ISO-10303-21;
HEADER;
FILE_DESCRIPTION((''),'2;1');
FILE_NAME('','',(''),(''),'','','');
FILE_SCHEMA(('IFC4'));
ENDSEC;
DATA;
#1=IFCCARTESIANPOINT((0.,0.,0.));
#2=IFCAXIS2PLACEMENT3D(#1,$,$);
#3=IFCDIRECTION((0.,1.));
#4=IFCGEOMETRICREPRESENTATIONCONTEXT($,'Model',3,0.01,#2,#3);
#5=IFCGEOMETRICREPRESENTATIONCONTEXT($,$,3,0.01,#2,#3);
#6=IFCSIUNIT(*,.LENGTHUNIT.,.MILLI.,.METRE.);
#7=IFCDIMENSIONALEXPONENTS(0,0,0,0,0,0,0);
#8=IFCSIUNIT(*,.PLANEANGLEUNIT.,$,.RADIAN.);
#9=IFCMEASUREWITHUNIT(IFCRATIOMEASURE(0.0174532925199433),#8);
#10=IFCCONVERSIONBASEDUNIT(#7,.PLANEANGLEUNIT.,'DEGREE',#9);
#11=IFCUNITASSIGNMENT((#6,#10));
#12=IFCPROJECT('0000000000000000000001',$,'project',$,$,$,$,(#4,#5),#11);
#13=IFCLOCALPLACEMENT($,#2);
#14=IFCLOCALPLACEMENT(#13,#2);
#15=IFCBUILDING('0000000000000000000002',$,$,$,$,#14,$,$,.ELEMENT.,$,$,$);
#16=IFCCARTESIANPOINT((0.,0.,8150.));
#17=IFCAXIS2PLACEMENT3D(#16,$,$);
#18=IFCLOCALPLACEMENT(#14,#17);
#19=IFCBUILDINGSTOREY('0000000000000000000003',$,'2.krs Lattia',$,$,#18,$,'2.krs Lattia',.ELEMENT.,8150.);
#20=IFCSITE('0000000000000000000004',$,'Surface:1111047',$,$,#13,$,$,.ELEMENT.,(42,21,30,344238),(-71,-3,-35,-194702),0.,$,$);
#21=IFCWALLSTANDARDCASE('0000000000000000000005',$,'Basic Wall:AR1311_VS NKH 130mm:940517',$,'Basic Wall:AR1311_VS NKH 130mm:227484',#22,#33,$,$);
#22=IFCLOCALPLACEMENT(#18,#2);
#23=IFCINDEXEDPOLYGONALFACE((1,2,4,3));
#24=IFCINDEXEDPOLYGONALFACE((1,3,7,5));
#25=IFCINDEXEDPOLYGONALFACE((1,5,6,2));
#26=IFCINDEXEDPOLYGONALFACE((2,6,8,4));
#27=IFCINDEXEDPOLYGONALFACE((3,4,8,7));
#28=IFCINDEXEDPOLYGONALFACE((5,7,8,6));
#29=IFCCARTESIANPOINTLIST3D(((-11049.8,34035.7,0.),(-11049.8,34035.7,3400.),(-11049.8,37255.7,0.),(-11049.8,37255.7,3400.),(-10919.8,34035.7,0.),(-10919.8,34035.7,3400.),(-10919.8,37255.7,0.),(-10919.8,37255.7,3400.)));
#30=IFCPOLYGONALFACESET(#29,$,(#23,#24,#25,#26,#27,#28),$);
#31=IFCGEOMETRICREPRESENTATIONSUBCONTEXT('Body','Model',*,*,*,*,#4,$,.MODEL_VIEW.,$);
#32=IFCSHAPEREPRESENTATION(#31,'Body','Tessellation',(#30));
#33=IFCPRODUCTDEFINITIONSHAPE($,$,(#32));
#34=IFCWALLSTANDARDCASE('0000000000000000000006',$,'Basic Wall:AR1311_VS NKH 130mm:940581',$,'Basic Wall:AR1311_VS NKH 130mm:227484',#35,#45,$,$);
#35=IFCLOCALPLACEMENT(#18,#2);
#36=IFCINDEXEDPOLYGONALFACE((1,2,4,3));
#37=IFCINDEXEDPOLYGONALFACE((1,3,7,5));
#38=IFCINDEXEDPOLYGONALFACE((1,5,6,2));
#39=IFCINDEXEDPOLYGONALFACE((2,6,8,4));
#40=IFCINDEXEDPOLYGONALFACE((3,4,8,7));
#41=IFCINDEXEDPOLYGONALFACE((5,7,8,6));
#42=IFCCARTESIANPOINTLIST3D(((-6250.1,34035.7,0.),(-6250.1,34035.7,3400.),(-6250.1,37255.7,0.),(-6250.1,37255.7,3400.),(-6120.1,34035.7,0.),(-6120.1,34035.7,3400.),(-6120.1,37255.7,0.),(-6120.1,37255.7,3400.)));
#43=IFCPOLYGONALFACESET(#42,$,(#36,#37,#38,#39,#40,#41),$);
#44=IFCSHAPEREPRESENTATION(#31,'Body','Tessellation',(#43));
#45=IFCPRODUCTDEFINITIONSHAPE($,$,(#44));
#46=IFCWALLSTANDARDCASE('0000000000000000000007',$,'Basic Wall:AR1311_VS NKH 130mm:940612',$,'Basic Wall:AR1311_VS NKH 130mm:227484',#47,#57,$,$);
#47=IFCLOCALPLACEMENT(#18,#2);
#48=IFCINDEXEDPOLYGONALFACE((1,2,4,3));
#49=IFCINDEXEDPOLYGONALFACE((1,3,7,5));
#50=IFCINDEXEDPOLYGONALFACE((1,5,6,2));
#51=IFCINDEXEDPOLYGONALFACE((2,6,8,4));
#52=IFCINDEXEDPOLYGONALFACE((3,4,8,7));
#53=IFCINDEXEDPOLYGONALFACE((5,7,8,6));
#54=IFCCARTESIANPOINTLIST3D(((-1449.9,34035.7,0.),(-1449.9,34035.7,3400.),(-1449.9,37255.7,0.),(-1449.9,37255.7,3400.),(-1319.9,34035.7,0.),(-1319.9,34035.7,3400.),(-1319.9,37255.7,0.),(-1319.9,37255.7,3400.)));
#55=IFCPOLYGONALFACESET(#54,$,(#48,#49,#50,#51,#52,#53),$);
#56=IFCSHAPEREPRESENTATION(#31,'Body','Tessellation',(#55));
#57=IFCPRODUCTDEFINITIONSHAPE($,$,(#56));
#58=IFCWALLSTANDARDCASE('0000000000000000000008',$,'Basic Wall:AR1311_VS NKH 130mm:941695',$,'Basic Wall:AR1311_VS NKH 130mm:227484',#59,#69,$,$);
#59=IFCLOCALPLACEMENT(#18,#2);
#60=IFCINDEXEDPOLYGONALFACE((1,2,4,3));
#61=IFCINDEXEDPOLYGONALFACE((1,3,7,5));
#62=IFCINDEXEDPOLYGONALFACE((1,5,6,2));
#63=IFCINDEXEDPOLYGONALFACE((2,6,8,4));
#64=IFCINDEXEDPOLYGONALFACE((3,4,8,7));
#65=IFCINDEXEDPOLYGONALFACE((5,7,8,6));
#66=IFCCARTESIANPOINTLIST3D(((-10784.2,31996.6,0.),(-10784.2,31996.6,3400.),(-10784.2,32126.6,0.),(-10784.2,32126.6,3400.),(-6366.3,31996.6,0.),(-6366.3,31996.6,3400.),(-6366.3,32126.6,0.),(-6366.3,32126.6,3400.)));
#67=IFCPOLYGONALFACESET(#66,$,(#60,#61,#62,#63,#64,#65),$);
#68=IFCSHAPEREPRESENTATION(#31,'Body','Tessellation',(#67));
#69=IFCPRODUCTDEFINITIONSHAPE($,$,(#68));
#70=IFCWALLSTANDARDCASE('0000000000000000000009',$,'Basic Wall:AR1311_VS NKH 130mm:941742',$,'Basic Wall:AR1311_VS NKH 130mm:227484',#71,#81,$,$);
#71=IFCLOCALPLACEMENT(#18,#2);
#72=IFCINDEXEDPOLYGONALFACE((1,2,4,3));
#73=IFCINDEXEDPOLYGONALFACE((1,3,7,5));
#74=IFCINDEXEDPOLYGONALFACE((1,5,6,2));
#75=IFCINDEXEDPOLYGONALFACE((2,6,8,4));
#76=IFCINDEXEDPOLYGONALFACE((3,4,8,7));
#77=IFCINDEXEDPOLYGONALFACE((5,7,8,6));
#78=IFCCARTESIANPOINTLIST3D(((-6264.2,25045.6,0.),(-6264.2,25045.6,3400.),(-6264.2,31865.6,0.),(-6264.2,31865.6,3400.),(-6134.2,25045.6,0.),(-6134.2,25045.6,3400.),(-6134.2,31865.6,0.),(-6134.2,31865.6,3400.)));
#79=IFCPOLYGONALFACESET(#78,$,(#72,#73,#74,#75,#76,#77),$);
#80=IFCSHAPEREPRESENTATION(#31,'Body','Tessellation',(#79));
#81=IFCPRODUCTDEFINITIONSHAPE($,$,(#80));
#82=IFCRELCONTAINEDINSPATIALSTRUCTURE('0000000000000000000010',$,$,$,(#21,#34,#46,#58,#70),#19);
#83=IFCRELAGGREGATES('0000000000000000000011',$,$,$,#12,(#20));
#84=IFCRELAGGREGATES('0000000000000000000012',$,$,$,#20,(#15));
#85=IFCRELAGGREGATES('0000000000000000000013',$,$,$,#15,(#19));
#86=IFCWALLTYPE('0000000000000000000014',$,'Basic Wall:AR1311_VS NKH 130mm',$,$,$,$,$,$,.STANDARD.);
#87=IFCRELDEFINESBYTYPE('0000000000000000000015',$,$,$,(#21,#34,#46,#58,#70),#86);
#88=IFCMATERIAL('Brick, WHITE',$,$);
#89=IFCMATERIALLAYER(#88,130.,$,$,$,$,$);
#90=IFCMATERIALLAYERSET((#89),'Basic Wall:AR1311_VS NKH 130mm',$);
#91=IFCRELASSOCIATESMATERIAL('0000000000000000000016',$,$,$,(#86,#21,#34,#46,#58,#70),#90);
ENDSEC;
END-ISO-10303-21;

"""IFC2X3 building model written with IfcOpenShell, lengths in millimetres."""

from ifc_helpers import new_model, entity, si_unit, converted_unit, direction, frame, frame_2d, origin, place, context, subcontext, project, spatial, rectangle, extrude, material, layer, layer_set, layer_usage, type_object, element, save


model = new_model("IFC2X3")

# Units and contexts
model_context = context("Model", 3, precision=0.01, world=origin(), true_north=direction((0.0, 1.0)))
context_of_model = context(None, 3, precision=0.01, world=origin(), true_north=direction((0.0, 1.0)))
body_context = subcontext(model_context, "Body", "Model", "MODEL_VIEW")
ifc_project = project(units=[si_unit("LENGTHUNIT", "METRE", prefix="MILLI"), converted_unit("PLANEANGLEUNIT", "DEGREE", entity("IfcRatioMeasure", 0.0174532925199433), si_unit("PLANEANGLEUNIT", "RADIAN"), dimensions=[0, 0, 0, 0, 0, 0, 0])], contexts=[model_context, context_of_model])

# Site, building, storey
site_placement = place(None, origin())
site = spatial("IfcSite", under=ifc_project, at=site_placement, Name="Surface:1111047", CompositionType="ELEMENT", RefLatitude=(42, 21, 30, 344238), RefLongitude=(-71, -3, -35, -194702), RefElevation=0.0)
building_placement = place(site_placement, origin())
building = spatial("IfcBuilding", under=site, at=building_placement, CompositionType="ELEMENT")
storey_placement = place(building_placement, frame((0.0, 0.0, 8150.0)))
storey = spatial("IfcBuildingStorey", under=building, at=storey_placement, Name="2.krs Lattia", LongName="2.krs Lattia", CompositionType="ELEMENT", Elevation=8150.0)

# Walls
ifc_material_1 = material(Name="Brick, WHITE")
ifc_layer = layer(ifc_material_1, 130.0)
ifc_layer_set = layer_set([ifc_layer], Name="Basic Wall:AR1311_VS NKH 130mm")
ifc_layer_usage_1 = layer_usage(ifc_layer_set, "AXIS2", "NEGATIVE", 65.0)
wall_type = type_object("IfcWallType", Name="Basic Wall:AR1311_VS NKH 130mm", PredefinedType="STANDARD", material=ifc_layer_set)
wall_1_placement = place(storey_placement, frame((-10984.8, 37255.7, 0.0), z_axis=(0.0, 0.0, 1.0), x_axis=(0.0, -1.0, 0.0)))
element("IfcWallStandardCase", 1, at=wall_1_placement, inside=storey, type_object=wall_type, material=ifc_layer_usage_1, Name="Basic Wall:AR1311_VS NKH 130mm:940517", ObjectType="Basic Wall:AR1311_VS NKH 130mm:227484", context=body_context, shape_type="SweptSolid", body=[
    extrude(rectangle(XDim=3220.0, YDim=130.0, at=frame_2d((1610.0, 0.0), x_axis=(-1.0, 0.0))), origin(), (0.0, 0.0, 1.0), 3400.0),
])
ifc_layer_usage_2 = layer_usage(ifc_layer_set, "AXIS2", "NEGATIVE", 65.0)
wall_2_placement = place(storey_placement, frame((-6185.1, 37255.7, 0.0), z_axis=(0.0, 0.0, 1.0), x_axis=(0.0, -1.0, 0.0)))
element("IfcWallStandardCase", 2, at=wall_2_placement, inside=storey, type_object=wall_type, material=ifc_layer_usage_2, Name="Basic Wall:AR1311_VS NKH 130mm:940581", ObjectType="Basic Wall:AR1311_VS NKH 130mm:227484", context=body_context, shape_type="SweptSolid", body=[
    extrude(rectangle(XDim=3220.0, YDim=130.0, at=frame_2d((1610.0, 0.0), x_axis=(-1.0, 0.0))), origin(), (0.0, 0.0, 1.0), 3400.0),
])
ifc_layer_usage_3 = layer_usage(ifc_layer_set, "AXIS2", "NEGATIVE", 65.0)
wall_3_placement = place(storey_placement, frame((-1384.9, 37255.7, 0.0), z_axis=(0.0, 0.0, 1.0), x_axis=(0.0, -1.0, 0.0)))
element("IfcWallStandardCase", 3, at=wall_3_placement, inside=storey, type_object=wall_type, material=ifc_layer_usage_3, Name="Basic Wall:AR1311_VS NKH 130mm:940612", ObjectType="Basic Wall:AR1311_VS NKH 130mm:227484", context=body_context, shape_type="SweptSolid", body=[
    extrude(rectangle(XDim=3220.0, YDim=130.0, at=frame_2d((1610.0, 0.0), x_axis=(-1.0, 0.0))), origin(), (0.0, 0.0, 1.0), 3400.0),
])
ifc_layer_usage_4 = layer_usage(ifc_layer_set, "AXIS2", "NEGATIVE", 65.0)
wall_4_placement = place(storey_placement, frame((-10784.2, 32061.6, 0.0)))
element("IfcWallStandardCase", 4, at=wall_4_placement, inside=storey, type_object=wall_type, material=ifc_layer_usage_4, Name="Basic Wall:AR1311_VS NKH 130mm:941695", ObjectType="Basic Wall:AR1311_VS NKH 130mm:227484", context=body_context, shape_type="SweptSolid", body=[
    extrude(rectangle(XDim=4417.9, YDim=130.0, at=frame_2d((2209.0, 0.0), x_axis=(-1.0, 0.0))), origin(), (0.0, 0.0, 1.0), 3400.0),
])
ifc_layer_usage_5 = layer_usage(ifc_layer_set, "AXIS2", "NEGATIVE", 65.0)
wall_5_placement = place(storey_placement, frame((-6199.2, 31865.6, 0.0), z_axis=(0.0, 0.0, 1.0), x_axis=(0.0, -1.0, 0.0)))
element("IfcWallStandardCase", 5, at=wall_5_placement, inside=storey, type_object=wall_type, material=ifc_layer_usage_5, Name="Basic Wall:AR1311_VS NKH 130mm:941742", ObjectType="Basic Wall:AR1311_VS NKH 130mm:227484", context=body_context, shape_type="SweptSolid", body=[
    extrude(rectangle(XDim=6820.0, YDim=130.0, at=frame_2d((3410.0, 0.0), x_axis=(-1.0, 0.0))), origin(), (0.0, 0.0, 1.0), 3400.0),
])

save(model, "model.ifc")
